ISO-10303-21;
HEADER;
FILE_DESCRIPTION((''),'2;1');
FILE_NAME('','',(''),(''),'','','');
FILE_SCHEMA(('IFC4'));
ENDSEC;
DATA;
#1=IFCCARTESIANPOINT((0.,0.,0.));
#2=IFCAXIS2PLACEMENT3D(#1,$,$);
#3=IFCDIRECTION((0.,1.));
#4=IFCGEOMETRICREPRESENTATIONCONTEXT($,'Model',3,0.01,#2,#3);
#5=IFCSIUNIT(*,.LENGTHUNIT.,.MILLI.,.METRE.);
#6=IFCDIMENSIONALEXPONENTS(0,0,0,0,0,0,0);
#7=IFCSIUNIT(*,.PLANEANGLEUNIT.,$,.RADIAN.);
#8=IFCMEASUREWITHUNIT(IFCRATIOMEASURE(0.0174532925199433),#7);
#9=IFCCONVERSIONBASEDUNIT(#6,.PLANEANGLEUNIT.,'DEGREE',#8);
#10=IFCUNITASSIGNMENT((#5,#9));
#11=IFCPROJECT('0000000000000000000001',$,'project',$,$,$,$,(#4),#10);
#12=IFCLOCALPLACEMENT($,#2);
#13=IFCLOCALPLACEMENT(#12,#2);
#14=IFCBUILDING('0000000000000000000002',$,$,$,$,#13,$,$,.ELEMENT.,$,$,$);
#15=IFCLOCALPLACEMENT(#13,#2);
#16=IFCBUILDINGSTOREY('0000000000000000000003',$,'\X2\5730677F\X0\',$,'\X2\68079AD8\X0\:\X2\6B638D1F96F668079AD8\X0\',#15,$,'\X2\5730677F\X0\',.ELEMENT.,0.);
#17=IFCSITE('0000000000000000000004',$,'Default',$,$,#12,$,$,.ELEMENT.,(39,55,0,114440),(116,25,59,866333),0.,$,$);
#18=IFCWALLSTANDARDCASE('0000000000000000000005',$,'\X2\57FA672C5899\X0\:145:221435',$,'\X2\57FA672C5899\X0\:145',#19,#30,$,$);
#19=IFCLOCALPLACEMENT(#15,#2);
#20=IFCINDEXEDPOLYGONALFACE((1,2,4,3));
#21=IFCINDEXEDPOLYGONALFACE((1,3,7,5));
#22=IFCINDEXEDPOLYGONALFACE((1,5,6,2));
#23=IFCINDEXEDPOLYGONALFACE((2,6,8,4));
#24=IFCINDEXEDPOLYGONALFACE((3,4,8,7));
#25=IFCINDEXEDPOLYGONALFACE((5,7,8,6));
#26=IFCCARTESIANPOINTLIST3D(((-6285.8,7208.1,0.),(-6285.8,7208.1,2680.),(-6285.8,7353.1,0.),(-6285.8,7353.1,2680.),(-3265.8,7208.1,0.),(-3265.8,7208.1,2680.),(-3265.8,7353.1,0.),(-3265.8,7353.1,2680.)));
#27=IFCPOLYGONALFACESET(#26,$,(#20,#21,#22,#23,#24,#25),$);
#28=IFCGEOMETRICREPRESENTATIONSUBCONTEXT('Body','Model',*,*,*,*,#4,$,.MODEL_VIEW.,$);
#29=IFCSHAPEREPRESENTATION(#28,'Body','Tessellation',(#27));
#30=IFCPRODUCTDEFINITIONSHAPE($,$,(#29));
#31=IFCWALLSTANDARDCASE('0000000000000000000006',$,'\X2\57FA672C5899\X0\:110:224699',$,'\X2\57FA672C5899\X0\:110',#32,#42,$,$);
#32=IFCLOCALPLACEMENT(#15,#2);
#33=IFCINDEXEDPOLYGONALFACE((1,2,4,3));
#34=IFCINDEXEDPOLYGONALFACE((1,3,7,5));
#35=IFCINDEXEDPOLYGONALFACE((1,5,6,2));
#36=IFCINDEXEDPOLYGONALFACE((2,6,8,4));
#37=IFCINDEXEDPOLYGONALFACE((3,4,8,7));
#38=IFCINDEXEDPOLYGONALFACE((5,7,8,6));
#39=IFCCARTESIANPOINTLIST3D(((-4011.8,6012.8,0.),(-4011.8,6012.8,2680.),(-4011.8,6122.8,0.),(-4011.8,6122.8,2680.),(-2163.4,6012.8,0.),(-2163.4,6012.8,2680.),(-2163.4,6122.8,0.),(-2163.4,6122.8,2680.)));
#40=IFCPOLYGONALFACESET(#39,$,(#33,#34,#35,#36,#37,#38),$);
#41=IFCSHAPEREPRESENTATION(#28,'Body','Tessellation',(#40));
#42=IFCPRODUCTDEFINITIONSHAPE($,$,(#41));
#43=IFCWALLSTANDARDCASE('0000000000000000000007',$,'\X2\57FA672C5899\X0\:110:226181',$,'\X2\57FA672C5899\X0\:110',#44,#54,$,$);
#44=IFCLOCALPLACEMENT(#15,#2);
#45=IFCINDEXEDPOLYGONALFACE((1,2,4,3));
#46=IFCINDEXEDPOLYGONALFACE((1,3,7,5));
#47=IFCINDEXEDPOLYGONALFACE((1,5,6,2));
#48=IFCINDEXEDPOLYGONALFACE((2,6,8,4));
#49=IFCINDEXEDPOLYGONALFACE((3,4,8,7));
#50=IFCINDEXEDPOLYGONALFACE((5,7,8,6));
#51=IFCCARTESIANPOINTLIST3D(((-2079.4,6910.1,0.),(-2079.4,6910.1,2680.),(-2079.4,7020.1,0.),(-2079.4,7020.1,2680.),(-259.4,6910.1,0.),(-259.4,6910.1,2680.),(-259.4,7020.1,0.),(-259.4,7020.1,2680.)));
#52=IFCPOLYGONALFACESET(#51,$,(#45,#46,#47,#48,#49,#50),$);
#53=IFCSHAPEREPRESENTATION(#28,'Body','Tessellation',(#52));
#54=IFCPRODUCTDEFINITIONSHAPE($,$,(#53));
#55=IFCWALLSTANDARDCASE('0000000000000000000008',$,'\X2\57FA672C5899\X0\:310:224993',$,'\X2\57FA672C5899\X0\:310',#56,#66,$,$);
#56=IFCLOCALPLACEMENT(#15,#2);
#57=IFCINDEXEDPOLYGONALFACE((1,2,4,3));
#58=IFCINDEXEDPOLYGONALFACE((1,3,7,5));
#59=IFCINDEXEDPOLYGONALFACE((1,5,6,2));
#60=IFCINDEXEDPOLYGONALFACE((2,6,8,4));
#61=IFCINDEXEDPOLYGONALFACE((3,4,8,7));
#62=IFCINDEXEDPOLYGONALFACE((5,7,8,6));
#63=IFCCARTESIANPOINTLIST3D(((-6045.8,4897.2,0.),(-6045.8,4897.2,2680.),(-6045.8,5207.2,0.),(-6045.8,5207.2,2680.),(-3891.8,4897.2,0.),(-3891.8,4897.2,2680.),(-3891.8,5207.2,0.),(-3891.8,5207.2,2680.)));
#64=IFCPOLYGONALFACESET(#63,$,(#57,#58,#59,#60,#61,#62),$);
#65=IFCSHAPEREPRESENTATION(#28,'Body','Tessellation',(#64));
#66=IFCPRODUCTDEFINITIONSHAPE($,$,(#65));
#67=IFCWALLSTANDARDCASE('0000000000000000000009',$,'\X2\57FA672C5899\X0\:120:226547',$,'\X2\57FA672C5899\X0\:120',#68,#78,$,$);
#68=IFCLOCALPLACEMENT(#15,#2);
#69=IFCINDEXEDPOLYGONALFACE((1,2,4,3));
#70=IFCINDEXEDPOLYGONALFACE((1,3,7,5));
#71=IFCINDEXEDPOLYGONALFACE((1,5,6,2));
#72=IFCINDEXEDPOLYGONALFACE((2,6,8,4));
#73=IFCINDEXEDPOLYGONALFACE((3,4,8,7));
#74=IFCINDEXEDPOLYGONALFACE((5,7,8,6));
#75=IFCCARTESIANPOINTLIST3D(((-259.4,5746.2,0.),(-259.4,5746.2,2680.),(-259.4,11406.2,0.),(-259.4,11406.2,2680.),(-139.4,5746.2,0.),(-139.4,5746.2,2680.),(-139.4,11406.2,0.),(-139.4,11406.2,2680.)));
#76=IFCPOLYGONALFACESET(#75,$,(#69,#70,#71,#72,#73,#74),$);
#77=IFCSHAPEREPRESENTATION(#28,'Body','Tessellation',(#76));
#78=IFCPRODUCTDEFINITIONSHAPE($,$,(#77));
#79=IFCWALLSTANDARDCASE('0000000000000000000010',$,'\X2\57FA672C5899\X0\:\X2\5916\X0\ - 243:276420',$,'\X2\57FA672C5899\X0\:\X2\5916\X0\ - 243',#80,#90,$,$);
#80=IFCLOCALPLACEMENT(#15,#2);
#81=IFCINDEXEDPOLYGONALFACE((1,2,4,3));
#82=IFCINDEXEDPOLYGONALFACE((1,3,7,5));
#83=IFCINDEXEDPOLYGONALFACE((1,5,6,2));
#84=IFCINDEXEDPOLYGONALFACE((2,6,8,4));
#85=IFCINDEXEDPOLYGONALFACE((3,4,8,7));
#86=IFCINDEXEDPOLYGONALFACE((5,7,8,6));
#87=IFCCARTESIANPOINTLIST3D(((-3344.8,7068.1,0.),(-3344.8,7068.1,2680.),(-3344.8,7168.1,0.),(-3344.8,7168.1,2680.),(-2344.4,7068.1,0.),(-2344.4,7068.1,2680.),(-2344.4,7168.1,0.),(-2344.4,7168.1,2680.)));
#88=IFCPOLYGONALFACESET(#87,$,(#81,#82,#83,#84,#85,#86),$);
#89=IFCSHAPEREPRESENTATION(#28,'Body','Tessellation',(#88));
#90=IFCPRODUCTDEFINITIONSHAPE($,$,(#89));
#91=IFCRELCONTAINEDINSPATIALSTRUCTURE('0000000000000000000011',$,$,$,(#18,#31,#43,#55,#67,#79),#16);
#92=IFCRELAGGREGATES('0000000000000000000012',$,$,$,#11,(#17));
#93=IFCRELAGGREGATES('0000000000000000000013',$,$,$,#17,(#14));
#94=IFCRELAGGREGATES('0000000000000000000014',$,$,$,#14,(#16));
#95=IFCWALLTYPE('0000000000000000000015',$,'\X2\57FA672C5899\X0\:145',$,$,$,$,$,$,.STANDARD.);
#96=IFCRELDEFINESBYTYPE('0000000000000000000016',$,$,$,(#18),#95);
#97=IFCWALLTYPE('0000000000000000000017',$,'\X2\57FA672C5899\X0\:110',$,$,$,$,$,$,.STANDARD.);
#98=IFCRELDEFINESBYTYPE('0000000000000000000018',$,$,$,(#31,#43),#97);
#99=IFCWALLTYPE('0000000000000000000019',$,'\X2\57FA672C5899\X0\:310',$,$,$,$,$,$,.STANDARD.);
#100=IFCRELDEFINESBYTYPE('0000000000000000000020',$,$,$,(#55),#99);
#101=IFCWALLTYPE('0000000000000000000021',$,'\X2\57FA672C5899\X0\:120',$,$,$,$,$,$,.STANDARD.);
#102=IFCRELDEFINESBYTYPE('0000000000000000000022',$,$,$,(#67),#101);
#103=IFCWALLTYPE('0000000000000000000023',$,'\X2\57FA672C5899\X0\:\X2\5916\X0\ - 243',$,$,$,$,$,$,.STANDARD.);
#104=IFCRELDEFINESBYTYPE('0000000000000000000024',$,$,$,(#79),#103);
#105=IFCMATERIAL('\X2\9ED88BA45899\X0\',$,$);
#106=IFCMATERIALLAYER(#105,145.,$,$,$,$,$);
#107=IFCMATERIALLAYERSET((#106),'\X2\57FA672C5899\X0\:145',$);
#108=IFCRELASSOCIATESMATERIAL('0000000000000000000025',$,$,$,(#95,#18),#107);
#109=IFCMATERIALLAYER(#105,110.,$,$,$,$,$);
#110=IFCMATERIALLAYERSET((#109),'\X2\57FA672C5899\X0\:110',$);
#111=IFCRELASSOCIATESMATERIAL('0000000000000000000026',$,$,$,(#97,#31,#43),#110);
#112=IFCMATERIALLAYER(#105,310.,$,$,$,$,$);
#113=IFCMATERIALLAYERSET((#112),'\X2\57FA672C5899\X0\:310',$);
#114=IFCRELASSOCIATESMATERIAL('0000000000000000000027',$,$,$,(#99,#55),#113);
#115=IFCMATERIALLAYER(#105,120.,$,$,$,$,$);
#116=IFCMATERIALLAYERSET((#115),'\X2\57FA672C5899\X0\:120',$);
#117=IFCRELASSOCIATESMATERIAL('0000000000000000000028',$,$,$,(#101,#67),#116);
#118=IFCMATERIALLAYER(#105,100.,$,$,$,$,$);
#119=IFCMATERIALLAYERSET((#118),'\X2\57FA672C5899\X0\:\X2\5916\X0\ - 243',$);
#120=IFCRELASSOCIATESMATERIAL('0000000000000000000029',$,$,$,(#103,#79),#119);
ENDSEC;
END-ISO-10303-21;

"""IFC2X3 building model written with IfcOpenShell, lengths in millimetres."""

from ifc_helpers import new_model, entity, si_unit, converted_unit, direction, frame, frame_2d, origin, place, context, subcontext, project, spatial, rectangle, extrude, material, layer, layer_set, layer_usage, type_object, element, save


model = new_model("IFC2X3")

# Units and contexts
model_context = context("Model", 3, precision=0.01, world=origin(), true_north=direction((0.0, 1.0)))
body_context = subcontext(model_context, "Body", "Model", "MODEL_VIEW")
ifc_project = project(units=[si_unit("LENGTHUNIT", "METRE", prefix="MILLI"), converted_unit("PLANEANGLEUNIT", "DEGREE", entity("IfcRatioMeasure", 0.0174532925199433), si_unit("PLANEANGLEUNIT", "RADIAN"), dimensions=[0, 0, 0, 0, 0, 0, 0])], contexts=[model_context])

# Site, building, storey
site_placement = place(None, origin())
site = spatial("IfcSite", under=ifc_project, at=site_placement, Name="Default", CompositionType="ELEMENT", RefLatitude=(39, 55, 0, 114440), RefLongitude=(116, 25, 59, 866333), RefElevation=0.0)
building_placement = place(site_placement, origin())
building = spatial("IfcBuilding", under=site, at=building_placement, CompositionType="ELEMENT")
storey_placement = place(building_placement, origin())
storey = spatial("IfcBuildingStorey", under=building, at=storey_placement, Name="地板", ObjectType="标高:正负零标高", LongName="地板", CompositionType="ELEMENT", Elevation=0.0)

# Shared definitions
ifc_material_1 = material(Name="默认墙")

# Walls
ifc_layer_1 = layer(ifc_material_1, 145.0)
ifc_layer_set_1 = layer_set([ifc_layer_1], Name="基本墙:145")
ifc_layer_usage_1 = layer_usage(ifc_layer_set_1, "AXIS2", "NEGATIVE", 72.5)
wall_type_1 = type_object("IfcWallType", Name="基本墙:145", PredefinedType="STANDARD", material=ifc_layer_set_1)
wall_1_placement = place(storey_placement, frame((-3265.8, 7280.6, 0.0), z_axis=(0.0, 0.0, 1.0), x_axis=(-1.0, 0.0, 0.0)))
element("IfcWallStandardCase", 1, at=wall_1_placement, inside=storey, type_object=wall_type_1, material=ifc_layer_usage_1, Name="基本墙:145:221435", ObjectType="基本墙:145", context=body_context, shape_type="SweptSolid", body=[
    extrude(rectangle(XDim=3020.0, YDim=145.0, at=frame_2d((1510.0, 0.0), x_axis=(-1.0, 0.0))), origin(), (0.0, 0.0, 1.0), 2680.0),
])
ifc_layer_2 = layer(ifc_material_1, 110.0)
ifc_layer_set_2 = layer_set([ifc_layer_2], Name="基本墙:110")
ifc_layer_usage_2 = layer_usage(ifc_layer_set_2, "AXIS2", "NEGATIVE", 55.0)
wall_type_2 = type_object("IfcWallType", Name="基本墙:110", PredefinedType="STANDARD", material=ifc_layer_set_2)
wall_2_placement = place(storey_placement, frame((-2163.4, 6067.8, 0.0), z_axis=(0.0, 0.0, 1.0), x_axis=(-1.0, 0.0, 0.0)))
element("IfcWallStandardCase", 2, at=wall_2_placement, inside=storey, type_object=wall_type_2, material=ifc_layer_usage_2, Name="基本墙:110:224699", ObjectType="基本墙:110", context=body_context, shape_type="SweptSolid", body=[
    extrude(rectangle(XDim=1848.4, YDim=110.0, at=frame_2d((924.2, 0.0), x_axis=(-1.0, 0.0))), origin(), (0.0, 0.0, 1.0), 2680.0),
])
ifc_layer_usage_3 = layer_usage(ifc_layer_set_2, "AXIS2", "NEGATIVE", 55.0)
wall_3_placement = place(storey_placement, frame((-2079.4, 6965.1, 0.0)))
element("IfcWallStandardCase", 3, at=wall_3_placement, inside=storey, type_object=wall_type_2, material=ifc_layer_usage_3, Name="基本墙:110:226181", ObjectType="基本墙:110", context=body_context, shape_type="SweptSolid", body=[
    extrude(rectangle(XDim=1820.0, YDim=110.0, at=frame_2d((910.0, 0.0), x_axis=(-1.0, 0.0))), origin(), (0.0, 0.0, 1.0), 2680.0),
])
ifc_layer_3 = layer(ifc_material_1, 310.0)
ifc_layer_set_3 = layer_set([ifc_layer_3], Name="基本墙:310")
ifc_layer_usage_4 = layer_usage(ifc_layer_set_3, "AXIS2", "NEGATIVE", 155.0)
wall_type_3 = type_object("IfcWallType", Name="基本墙:310", PredefinedType="STANDARD", material=ifc_layer_set_3)
wall_4_placement = place(storey_placement, frame((-6045.8, 5052.2, 0.0)))
element("IfcWallStandardCase", 4, at=wall_4_placement, inside=storey, type_object=wall_type_3, material=ifc_layer_usage_4, Name="基本墙:310:224993", ObjectType="基本墙:310", context=body_context, shape_type="SweptSolid", body=[
    extrude(rectangle(XDim=2154.0, YDim=310.0, at=frame_2d((1077.0, 0.0), x_axis=(-1.0, 0.0))), origin(), (0.0, 0.0, 1.0), 2680.0),
])
ifc_layer_4 = layer(ifc_material_1, 120.0)
ifc_layer_set_4 = layer_set([ifc_layer_4], Name="基本墙:120")
ifc_layer_usage_5 = layer_usage(ifc_layer_set_4, "AXIS2", "NEGATIVE", 60.0)
wall_type_4 = type_object("IfcWallType", Name="基本墙:120", PredefinedType="STANDARD", material=ifc_layer_set_4)
wall_5_placement = place(storey_placement, frame((-199.4, 5746.2, 0.0), z_axis=(0.0, 0.0, 1.0), x_axis=(0.0, 1.0, 0.0)))
element("IfcWallStandardCase", 5, at=wall_5_placement, inside=storey, type_object=wall_type_4, material=ifc_layer_usage_5, Name="基本墙:120:226547", ObjectType="基本墙:120", context=body_context, shape_type="SweptSolid", body=[
    extrude(rectangle(XDim=5660.0, YDim=120.0, at=frame_2d((2830.0, 0.0), x_axis=(-1.0, 0.0))), origin(), (0.0, 0.0, 1.0), 2680.0),
])
ifc_layer_5 = layer(ifc_material_1, 100.0)
ifc_layer_set_5 = layer_set([ifc_layer_5], Name="基本墙:外 - 243")
ifc_layer_usage_6 = layer_usage(ifc_layer_set_5, "AXIS2", "NEGATIVE", 50.0)
wall_type_5 = type_object("IfcWallType", Name="基本墙:外 - 243", PredefinedType="STANDARD", material=ifc_layer_set_5)
wall_6_placement = place(storey_placement, frame((-3344.8, 7118.1, 0.0)))
element("IfcWallStandardCase", 6, at=wall_6_placement, inside=storey, type_object=wall_type_5, material=ifc_layer_usage_6, Name="基本墙:外 - 243:276420", ObjectType="基本墙:外 - 243", context=body_context, shape_type="SweptSolid", body=[
    extrude(rectangle(XDim=1000.3, YDim=100.0, at=frame_2d((500.2, 0.0), x_axis=(-1.0, 0.0))), origin(), (0.0, 0.0, 1.0), 2680.0),
])

save(model, "model.ifc")
